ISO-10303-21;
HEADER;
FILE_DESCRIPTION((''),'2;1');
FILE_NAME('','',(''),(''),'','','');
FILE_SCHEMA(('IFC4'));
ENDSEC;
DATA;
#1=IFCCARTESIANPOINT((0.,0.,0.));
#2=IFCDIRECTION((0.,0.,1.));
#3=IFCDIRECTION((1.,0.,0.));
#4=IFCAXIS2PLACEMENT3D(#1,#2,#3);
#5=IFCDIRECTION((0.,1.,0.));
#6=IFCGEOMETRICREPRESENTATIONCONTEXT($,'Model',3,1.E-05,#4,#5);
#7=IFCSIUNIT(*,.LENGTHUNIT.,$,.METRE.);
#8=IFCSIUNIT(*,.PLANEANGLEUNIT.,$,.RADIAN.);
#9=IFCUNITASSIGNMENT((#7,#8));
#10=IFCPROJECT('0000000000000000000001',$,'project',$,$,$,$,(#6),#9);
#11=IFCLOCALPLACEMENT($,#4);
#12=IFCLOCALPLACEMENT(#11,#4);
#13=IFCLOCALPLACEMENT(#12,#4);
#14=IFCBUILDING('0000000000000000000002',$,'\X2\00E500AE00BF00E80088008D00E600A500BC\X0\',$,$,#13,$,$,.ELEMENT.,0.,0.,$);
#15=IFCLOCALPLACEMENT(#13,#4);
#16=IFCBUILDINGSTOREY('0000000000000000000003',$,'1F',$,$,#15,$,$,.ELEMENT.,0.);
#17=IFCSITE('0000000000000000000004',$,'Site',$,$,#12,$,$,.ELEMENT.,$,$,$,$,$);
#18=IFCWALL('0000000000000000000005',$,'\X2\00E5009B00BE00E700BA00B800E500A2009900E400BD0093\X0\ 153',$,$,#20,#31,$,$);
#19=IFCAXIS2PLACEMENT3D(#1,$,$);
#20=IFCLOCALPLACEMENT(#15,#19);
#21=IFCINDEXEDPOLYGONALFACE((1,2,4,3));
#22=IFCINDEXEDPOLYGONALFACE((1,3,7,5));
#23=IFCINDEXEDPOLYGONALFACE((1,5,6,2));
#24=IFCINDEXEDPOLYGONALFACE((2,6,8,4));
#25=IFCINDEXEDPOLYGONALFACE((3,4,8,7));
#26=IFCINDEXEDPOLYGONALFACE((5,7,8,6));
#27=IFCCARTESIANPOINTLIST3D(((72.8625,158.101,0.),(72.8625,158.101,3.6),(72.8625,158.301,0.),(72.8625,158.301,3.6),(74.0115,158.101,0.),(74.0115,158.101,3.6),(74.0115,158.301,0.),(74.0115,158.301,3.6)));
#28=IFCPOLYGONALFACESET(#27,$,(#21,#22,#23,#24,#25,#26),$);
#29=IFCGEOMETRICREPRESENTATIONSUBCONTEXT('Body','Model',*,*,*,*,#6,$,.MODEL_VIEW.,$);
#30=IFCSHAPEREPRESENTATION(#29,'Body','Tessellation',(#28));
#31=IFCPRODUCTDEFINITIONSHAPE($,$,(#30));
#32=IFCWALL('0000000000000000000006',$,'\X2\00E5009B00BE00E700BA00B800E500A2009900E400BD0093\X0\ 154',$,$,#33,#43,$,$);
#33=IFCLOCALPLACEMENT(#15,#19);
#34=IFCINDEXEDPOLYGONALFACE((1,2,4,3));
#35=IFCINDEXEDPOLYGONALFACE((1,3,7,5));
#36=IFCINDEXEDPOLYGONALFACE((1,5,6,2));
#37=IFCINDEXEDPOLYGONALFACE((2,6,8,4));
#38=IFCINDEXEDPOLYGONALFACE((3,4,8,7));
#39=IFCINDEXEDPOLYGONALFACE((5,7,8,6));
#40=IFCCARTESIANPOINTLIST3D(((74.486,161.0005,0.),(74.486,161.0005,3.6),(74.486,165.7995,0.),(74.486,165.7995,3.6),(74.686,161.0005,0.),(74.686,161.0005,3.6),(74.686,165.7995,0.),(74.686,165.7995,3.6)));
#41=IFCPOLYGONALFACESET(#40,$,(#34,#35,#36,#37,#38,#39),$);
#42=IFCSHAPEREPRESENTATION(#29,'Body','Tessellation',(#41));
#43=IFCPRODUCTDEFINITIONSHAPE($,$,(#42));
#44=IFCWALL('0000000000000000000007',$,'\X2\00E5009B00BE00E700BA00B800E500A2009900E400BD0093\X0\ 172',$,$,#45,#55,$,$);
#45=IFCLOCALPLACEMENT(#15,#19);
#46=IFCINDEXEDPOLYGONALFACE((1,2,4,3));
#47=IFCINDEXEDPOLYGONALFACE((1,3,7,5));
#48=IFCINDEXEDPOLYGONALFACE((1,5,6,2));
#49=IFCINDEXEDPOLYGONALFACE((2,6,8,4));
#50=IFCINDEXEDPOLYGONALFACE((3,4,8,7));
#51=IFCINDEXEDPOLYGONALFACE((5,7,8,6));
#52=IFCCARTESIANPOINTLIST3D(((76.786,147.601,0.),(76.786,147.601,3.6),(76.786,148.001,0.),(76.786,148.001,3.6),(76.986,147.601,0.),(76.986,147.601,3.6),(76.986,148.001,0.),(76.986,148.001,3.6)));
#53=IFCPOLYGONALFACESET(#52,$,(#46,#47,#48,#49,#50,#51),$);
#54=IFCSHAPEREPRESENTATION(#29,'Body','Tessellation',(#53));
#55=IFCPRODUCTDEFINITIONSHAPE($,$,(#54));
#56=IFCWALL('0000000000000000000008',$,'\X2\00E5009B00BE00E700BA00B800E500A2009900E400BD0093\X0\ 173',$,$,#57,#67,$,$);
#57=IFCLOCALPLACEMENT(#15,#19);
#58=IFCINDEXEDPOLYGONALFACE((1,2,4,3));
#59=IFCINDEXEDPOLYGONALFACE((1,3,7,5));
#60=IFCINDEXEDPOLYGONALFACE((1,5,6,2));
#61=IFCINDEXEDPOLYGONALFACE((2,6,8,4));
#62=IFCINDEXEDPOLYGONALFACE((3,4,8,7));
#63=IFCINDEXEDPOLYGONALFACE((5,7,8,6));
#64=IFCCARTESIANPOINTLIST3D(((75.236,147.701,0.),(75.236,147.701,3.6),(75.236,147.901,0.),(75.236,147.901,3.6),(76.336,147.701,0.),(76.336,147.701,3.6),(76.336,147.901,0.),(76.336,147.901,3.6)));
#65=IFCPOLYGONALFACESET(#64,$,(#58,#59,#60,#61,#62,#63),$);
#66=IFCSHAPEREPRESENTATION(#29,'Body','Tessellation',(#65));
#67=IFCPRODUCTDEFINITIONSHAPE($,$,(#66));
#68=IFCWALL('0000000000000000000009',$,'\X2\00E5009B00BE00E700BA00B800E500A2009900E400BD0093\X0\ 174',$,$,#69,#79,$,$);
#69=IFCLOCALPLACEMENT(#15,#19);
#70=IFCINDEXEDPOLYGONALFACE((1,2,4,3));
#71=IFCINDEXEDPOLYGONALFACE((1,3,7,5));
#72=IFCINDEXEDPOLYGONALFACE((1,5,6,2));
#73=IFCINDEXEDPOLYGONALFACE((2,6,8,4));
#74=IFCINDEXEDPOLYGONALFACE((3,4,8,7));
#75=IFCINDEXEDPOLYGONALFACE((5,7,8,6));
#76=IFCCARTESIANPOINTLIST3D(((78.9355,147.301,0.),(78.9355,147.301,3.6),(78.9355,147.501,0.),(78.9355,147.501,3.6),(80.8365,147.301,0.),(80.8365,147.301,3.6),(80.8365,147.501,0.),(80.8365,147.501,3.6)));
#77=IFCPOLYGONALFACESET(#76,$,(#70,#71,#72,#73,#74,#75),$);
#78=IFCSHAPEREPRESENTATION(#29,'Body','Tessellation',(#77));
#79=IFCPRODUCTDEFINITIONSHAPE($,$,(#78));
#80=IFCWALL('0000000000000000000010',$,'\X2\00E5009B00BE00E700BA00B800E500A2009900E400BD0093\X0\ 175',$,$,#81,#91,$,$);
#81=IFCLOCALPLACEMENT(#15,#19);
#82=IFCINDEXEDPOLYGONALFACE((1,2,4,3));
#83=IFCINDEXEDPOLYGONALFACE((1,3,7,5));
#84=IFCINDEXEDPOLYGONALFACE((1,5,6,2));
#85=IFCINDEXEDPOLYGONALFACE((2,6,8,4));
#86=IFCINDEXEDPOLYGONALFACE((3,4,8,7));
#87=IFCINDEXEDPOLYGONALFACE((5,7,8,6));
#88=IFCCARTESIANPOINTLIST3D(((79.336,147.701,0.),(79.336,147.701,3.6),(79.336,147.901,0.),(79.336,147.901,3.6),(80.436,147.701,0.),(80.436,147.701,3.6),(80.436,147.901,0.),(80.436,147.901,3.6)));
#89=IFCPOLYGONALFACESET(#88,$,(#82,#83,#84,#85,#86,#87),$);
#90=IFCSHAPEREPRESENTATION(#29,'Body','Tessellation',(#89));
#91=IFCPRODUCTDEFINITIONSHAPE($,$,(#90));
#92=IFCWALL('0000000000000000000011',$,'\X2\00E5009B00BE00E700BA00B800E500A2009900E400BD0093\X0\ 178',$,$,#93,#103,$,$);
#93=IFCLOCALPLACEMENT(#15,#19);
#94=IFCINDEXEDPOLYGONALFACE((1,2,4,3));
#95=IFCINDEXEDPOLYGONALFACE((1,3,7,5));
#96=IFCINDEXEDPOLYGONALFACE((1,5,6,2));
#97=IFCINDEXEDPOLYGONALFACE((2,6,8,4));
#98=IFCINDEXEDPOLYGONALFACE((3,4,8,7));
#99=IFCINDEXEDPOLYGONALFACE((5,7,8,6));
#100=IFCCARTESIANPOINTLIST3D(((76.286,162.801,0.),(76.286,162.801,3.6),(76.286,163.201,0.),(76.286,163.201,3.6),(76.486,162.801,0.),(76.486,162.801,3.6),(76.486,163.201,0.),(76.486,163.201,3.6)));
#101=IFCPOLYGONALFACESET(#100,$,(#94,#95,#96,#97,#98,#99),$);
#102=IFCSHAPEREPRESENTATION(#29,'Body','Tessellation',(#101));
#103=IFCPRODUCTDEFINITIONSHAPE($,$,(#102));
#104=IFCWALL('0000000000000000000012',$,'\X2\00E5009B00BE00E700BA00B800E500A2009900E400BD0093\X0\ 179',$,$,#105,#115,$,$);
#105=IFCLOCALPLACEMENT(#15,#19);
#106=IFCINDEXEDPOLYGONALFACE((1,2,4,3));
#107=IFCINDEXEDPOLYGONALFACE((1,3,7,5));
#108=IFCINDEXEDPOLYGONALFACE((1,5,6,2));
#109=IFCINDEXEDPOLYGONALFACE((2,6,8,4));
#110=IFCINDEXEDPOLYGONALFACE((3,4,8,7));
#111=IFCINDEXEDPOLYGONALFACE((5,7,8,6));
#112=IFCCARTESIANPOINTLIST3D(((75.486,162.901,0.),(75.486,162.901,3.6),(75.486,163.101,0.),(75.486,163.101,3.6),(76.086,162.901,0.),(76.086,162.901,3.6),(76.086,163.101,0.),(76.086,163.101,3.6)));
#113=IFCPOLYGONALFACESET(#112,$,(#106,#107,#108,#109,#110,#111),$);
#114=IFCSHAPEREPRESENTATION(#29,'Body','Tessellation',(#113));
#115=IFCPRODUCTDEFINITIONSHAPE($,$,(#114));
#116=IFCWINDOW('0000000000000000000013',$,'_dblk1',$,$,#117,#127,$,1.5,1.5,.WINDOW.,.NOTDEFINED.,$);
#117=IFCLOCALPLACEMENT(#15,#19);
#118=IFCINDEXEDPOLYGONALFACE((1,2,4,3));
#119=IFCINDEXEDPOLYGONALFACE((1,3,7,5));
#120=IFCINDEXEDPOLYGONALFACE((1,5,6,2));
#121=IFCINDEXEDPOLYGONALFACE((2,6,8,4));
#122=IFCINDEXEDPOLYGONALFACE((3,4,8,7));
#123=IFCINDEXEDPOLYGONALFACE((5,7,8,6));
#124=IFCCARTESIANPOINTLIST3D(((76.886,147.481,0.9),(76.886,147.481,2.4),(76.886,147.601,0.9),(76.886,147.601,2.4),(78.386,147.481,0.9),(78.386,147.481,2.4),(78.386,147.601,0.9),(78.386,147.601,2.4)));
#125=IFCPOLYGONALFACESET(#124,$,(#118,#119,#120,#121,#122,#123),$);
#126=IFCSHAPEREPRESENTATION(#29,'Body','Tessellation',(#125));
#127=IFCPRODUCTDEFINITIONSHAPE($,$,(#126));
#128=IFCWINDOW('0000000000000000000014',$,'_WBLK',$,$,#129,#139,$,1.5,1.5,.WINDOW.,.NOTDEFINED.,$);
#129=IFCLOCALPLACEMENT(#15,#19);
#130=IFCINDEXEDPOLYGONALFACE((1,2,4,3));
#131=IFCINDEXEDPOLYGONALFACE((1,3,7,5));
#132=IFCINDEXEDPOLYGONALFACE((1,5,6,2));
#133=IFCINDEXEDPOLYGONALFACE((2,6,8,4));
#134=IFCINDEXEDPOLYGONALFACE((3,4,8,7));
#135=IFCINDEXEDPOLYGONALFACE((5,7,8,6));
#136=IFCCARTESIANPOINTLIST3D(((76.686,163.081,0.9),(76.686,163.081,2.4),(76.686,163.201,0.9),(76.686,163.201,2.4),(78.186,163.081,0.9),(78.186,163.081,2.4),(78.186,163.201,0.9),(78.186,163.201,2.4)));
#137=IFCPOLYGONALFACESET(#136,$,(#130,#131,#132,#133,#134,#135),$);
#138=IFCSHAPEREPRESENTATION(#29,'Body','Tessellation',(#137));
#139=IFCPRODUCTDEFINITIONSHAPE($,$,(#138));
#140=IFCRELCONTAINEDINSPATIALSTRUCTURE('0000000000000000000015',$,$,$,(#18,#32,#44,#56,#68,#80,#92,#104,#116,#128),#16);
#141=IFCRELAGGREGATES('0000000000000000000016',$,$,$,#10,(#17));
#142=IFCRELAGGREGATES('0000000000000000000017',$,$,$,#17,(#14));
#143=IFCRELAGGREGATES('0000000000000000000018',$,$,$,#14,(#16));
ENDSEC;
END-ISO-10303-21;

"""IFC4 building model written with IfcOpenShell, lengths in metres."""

from ifc_helpers import new_model, si_unit, direction, frame, frame_2d, origin_with_axes, place, context, subcontext, project, spatial, rectangle, extrude, element, save


model = new_model("IFC4")

# Units and contexts
model_context = context("Model", 3, precision=1e-05, world=origin_with_axes(), true_north=direction((0.0, 1.0, 0.0)))
body_context = subcontext(model_context, "Body", "Model", "MODEL_VIEW")
ifc_project = project(units=[si_unit("LENGTHUNIT", "METRE"), si_unit("PLANEANGLEUNIT", "RADIAN")], contexts=[model_context])

# Site, building, storey
placement = place(None, origin_with_axes())
site_placement = place(placement, origin_with_axes())
site = spatial("IfcSite", under=ifc_project, at=site_placement, Name="Site", CompositionType="ELEMENT")
building_placement = place(site_placement, origin_with_axes())
building = spatial("IfcBuilding", under=site, at=building_placement, Name="å®¿è\u0088\u008dæ¥¼", CompositionType="ELEMENT", ElevationOfRefHeight=0.0, ElevationOfTerrain=0.0)
storey_placement = place(building_placement, origin_with_axes())
storey = spatial("IfcBuildingStorey", under=building, at=storey_placement, Name="1F", CompositionType="ELEMENT", Elevation=0.0)

# Walls
for number, where, z_axis, x_axis, name in (
    (1, (73.437, 158.201, 0.0), (0.0, 0.0, 1.0), (1.0, 0.0, 0.0), "å\u009b¾çº¸å¢\u0099ä½\u0093 153"),
):
    element("IfcWall", number, at=place(storey_placement, frame(where, z_axis=z_axis, x_axis=x_axis)), inside=storey, Name=name, context=body_context, shape_type="SweptSolid", body=[
        extrude(rectangle(XDim=1.149, YDim=0.2, at=frame_2d((0.0, 0.0), x_axis=(1.0, 0.0, 0.0))), frame((0.0, 0.0, 0.0), z_axis=(0.0, 0.0, 1.0)), (0.0, 0.0, 1.0), 3.6),
    ])
wall_1_placement = place(storey_placement, frame((74.586, 163.4, 0.0), z_axis=(0.0, 0.0, 1.0), x_axis=(0.0, -1.0, 0.0)))
element("IfcWall", 2, at=wall_1_placement, inside=storey, Name="å\u009b¾çº¸å¢\u0099ä½\u0093 154", context=body_context, shape_type="SweptSolid", body=[
    extrude(rectangle(XDim=4.799, YDim=0.2, at=frame_2d((0.0, 0.0), x_axis=(1.0, 0.0, 0.0))), frame((0.0, 0.0, 0.0), z_axis=(0.0, 0.0, 1.0)), (0.0, 0.0, 1.0), 3.6),
])
wall_2_placement = place(storey_placement, frame((76.886, 147.801, 0.0), z_axis=(0.0, 0.0, 1.0), x_axis=(0.0, -1.0, 0.0)))
element("IfcWall", 3, at=wall_2_placement, inside=storey, Name="å\u009b¾çº¸å¢\u0099ä½\u0093 172", context=body_context, shape_type="SweptSolid", body=[
    extrude(rectangle(XDim=0.4, YDim=0.2, at=frame_2d((0.0, 0.0), x_axis=(1.0, 0.0, 0.0))), frame((0.0, 0.0, 0.0), z_axis=(0.0, 0.0, 1.0)), (0.0, 0.0, 1.0), 3.6),
])
wall_3_placement = place(storey_placement, frame((75.786, 147.801, 0.0), z_axis=(0.0, 0.0, 1.0), x_axis=(1.0, 0.0, 0.0)))
element("IfcWall", 4, at=wall_3_placement, inside=storey, Name="å\u009b¾çº¸å¢\u0099ä½\u0093 173", context=body_context, shape_type="SweptSolid", body=[
    extrude(rectangle(XDim=1.1, YDim=0.2, at=frame_2d((0.0, 0.0), x_axis=(1.0, 0.0, 0.0))), frame((0.0, 0.0, 0.0), z_axis=(0.0, 0.0, 1.0)), (0.0, 0.0, 1.0), 3.6),
])
wall_4_placement = place(storey_placement, frame((79.886, 147.401, 0.0), z_axis=(0.0, 0.0, 1.0), x_axis=(1.0, 0.0, 0.0)))
element("IfcWall", 5, at=wall_4_placement, inside=storey, Name="å\u009b¾çº¸å¢\u0099ä½\u0093 174", context=body_context, shape_type="SweptSolid", body=[
    extrude(rectangle(XDim=1.901, YDim=0.2, at=frame_2d((0.0, 0.0), x_axis=(1.0, 0.0, 0.0))), frame((0.0, 0.0, 0.0), z_axis=(0.0, 0.0, 1.0)), (0.0, 0.0, 1.0), 3.6),
])
wall_5_placement = place(storey_placement, frame((79.886, 147.801, 0.0), z_axis=(0.0, 0.0, 1.0), x_axis=(1.0, 0.0, 0.0)))
element("IfcWall", 6, at=wall_5_placement, inside=storey, Name="å\u009b¾çº¸å¢\u0099ä½\u0093 175", context=body_context, shape_type="SweptSolid", body=[
    extrude(rectangle(XDim=1.1, YDim=0.2, at=frame_2d((0.0, 0.0), x_axis=(1.0, 0.0, 0.0))), frame((0.0, 0.0, 0.0), z_axis=(0.0, 0.0, 1.0)), (0.0, 0.0, 1.0), 3.6),
])
wall_6_placement = place(storey_placement, frame((76.386, 163.001, 0.0), z_axis=(0.0, 0.0, 1.0), x_axis=(0.0, 1.0, 0.0)))
element("IfcWall", 7, at=wall_6_placement, inside=storey, Name="å\u009b¾çº¸å¢\u0099ä½\u0093 178", context=body_context, shape_type="SweptSolid", body=[
    extrude(rectangle(XDim=0.4, YDim=0.2, at=frame_2d((0.0, 0.0), x_axis=(1.0, 0.0, 0.0))), frame((0.0, 0.0, 0.0), z_axis=(0.0, 0.0, 1.0)), (0.0, 0.0, 1.0), 3.6),
])
wall_7_placement = place(storey_placement, frame((75.786, 163.001, 0.0), z_axis=(0.0, 0.0, 1.0), x_axis=(1.0, 0.0, 0.0)))
element("IfcWall", 8, at=wall_7_placement, inside=storey, Name="å\u009b¾çº¸å¢\u0099ä½\u0093 179", context=body_context, shape_type="SweptSolid", body=[
    extrude(rectangle(XDim=0.6, YDim=0.2, at=frame_2d((0.0, 0.0), x_axis=(1.0, 0.0, 0.0))), frame((0.0, 0.0, 0.0), z_axis=(0.0, 0.0, 1.0)), (0.0, 0.0, 1.0), 3.6),
])

# Windows
for number, where, z_axis, x_axis, name in (
    (9, (77.636, 147.541, 0.9), (0.0, 0.0, 1.0), (1.0, 0.0, 0.0), "_dblk1"),
    (10, (77.436, 163.141, 0.9), (0.0, 0.0, 1.0), (1.0, 0.0, 0.0), "_WBLK"),
):
    element("IfcWindow", number, at=place(storey_placement, frame(where, z_axis=z_axis, x_axis=x_axis)), inside=storey, Name=name, OverallHeight=1.5, OverallWidth=1.5, PartitioningType="NOTDEFINED", PredefinedType="WINDOW", context=body_context, shape_type="SweptSolid", body=[
        extrude(rectangle(XDim=1.5, YDim=0.12, at=frame_2d((0.0, 0.0), x_axis=(1.0, 0.0, 0.0))), frame((0.0, 0.0, 0.0), z_axis=(0.0, 0.0, 1.0)), (0.0, 0.0, 1.0), 1.5),
    ])

save(model, "model.ifc")
